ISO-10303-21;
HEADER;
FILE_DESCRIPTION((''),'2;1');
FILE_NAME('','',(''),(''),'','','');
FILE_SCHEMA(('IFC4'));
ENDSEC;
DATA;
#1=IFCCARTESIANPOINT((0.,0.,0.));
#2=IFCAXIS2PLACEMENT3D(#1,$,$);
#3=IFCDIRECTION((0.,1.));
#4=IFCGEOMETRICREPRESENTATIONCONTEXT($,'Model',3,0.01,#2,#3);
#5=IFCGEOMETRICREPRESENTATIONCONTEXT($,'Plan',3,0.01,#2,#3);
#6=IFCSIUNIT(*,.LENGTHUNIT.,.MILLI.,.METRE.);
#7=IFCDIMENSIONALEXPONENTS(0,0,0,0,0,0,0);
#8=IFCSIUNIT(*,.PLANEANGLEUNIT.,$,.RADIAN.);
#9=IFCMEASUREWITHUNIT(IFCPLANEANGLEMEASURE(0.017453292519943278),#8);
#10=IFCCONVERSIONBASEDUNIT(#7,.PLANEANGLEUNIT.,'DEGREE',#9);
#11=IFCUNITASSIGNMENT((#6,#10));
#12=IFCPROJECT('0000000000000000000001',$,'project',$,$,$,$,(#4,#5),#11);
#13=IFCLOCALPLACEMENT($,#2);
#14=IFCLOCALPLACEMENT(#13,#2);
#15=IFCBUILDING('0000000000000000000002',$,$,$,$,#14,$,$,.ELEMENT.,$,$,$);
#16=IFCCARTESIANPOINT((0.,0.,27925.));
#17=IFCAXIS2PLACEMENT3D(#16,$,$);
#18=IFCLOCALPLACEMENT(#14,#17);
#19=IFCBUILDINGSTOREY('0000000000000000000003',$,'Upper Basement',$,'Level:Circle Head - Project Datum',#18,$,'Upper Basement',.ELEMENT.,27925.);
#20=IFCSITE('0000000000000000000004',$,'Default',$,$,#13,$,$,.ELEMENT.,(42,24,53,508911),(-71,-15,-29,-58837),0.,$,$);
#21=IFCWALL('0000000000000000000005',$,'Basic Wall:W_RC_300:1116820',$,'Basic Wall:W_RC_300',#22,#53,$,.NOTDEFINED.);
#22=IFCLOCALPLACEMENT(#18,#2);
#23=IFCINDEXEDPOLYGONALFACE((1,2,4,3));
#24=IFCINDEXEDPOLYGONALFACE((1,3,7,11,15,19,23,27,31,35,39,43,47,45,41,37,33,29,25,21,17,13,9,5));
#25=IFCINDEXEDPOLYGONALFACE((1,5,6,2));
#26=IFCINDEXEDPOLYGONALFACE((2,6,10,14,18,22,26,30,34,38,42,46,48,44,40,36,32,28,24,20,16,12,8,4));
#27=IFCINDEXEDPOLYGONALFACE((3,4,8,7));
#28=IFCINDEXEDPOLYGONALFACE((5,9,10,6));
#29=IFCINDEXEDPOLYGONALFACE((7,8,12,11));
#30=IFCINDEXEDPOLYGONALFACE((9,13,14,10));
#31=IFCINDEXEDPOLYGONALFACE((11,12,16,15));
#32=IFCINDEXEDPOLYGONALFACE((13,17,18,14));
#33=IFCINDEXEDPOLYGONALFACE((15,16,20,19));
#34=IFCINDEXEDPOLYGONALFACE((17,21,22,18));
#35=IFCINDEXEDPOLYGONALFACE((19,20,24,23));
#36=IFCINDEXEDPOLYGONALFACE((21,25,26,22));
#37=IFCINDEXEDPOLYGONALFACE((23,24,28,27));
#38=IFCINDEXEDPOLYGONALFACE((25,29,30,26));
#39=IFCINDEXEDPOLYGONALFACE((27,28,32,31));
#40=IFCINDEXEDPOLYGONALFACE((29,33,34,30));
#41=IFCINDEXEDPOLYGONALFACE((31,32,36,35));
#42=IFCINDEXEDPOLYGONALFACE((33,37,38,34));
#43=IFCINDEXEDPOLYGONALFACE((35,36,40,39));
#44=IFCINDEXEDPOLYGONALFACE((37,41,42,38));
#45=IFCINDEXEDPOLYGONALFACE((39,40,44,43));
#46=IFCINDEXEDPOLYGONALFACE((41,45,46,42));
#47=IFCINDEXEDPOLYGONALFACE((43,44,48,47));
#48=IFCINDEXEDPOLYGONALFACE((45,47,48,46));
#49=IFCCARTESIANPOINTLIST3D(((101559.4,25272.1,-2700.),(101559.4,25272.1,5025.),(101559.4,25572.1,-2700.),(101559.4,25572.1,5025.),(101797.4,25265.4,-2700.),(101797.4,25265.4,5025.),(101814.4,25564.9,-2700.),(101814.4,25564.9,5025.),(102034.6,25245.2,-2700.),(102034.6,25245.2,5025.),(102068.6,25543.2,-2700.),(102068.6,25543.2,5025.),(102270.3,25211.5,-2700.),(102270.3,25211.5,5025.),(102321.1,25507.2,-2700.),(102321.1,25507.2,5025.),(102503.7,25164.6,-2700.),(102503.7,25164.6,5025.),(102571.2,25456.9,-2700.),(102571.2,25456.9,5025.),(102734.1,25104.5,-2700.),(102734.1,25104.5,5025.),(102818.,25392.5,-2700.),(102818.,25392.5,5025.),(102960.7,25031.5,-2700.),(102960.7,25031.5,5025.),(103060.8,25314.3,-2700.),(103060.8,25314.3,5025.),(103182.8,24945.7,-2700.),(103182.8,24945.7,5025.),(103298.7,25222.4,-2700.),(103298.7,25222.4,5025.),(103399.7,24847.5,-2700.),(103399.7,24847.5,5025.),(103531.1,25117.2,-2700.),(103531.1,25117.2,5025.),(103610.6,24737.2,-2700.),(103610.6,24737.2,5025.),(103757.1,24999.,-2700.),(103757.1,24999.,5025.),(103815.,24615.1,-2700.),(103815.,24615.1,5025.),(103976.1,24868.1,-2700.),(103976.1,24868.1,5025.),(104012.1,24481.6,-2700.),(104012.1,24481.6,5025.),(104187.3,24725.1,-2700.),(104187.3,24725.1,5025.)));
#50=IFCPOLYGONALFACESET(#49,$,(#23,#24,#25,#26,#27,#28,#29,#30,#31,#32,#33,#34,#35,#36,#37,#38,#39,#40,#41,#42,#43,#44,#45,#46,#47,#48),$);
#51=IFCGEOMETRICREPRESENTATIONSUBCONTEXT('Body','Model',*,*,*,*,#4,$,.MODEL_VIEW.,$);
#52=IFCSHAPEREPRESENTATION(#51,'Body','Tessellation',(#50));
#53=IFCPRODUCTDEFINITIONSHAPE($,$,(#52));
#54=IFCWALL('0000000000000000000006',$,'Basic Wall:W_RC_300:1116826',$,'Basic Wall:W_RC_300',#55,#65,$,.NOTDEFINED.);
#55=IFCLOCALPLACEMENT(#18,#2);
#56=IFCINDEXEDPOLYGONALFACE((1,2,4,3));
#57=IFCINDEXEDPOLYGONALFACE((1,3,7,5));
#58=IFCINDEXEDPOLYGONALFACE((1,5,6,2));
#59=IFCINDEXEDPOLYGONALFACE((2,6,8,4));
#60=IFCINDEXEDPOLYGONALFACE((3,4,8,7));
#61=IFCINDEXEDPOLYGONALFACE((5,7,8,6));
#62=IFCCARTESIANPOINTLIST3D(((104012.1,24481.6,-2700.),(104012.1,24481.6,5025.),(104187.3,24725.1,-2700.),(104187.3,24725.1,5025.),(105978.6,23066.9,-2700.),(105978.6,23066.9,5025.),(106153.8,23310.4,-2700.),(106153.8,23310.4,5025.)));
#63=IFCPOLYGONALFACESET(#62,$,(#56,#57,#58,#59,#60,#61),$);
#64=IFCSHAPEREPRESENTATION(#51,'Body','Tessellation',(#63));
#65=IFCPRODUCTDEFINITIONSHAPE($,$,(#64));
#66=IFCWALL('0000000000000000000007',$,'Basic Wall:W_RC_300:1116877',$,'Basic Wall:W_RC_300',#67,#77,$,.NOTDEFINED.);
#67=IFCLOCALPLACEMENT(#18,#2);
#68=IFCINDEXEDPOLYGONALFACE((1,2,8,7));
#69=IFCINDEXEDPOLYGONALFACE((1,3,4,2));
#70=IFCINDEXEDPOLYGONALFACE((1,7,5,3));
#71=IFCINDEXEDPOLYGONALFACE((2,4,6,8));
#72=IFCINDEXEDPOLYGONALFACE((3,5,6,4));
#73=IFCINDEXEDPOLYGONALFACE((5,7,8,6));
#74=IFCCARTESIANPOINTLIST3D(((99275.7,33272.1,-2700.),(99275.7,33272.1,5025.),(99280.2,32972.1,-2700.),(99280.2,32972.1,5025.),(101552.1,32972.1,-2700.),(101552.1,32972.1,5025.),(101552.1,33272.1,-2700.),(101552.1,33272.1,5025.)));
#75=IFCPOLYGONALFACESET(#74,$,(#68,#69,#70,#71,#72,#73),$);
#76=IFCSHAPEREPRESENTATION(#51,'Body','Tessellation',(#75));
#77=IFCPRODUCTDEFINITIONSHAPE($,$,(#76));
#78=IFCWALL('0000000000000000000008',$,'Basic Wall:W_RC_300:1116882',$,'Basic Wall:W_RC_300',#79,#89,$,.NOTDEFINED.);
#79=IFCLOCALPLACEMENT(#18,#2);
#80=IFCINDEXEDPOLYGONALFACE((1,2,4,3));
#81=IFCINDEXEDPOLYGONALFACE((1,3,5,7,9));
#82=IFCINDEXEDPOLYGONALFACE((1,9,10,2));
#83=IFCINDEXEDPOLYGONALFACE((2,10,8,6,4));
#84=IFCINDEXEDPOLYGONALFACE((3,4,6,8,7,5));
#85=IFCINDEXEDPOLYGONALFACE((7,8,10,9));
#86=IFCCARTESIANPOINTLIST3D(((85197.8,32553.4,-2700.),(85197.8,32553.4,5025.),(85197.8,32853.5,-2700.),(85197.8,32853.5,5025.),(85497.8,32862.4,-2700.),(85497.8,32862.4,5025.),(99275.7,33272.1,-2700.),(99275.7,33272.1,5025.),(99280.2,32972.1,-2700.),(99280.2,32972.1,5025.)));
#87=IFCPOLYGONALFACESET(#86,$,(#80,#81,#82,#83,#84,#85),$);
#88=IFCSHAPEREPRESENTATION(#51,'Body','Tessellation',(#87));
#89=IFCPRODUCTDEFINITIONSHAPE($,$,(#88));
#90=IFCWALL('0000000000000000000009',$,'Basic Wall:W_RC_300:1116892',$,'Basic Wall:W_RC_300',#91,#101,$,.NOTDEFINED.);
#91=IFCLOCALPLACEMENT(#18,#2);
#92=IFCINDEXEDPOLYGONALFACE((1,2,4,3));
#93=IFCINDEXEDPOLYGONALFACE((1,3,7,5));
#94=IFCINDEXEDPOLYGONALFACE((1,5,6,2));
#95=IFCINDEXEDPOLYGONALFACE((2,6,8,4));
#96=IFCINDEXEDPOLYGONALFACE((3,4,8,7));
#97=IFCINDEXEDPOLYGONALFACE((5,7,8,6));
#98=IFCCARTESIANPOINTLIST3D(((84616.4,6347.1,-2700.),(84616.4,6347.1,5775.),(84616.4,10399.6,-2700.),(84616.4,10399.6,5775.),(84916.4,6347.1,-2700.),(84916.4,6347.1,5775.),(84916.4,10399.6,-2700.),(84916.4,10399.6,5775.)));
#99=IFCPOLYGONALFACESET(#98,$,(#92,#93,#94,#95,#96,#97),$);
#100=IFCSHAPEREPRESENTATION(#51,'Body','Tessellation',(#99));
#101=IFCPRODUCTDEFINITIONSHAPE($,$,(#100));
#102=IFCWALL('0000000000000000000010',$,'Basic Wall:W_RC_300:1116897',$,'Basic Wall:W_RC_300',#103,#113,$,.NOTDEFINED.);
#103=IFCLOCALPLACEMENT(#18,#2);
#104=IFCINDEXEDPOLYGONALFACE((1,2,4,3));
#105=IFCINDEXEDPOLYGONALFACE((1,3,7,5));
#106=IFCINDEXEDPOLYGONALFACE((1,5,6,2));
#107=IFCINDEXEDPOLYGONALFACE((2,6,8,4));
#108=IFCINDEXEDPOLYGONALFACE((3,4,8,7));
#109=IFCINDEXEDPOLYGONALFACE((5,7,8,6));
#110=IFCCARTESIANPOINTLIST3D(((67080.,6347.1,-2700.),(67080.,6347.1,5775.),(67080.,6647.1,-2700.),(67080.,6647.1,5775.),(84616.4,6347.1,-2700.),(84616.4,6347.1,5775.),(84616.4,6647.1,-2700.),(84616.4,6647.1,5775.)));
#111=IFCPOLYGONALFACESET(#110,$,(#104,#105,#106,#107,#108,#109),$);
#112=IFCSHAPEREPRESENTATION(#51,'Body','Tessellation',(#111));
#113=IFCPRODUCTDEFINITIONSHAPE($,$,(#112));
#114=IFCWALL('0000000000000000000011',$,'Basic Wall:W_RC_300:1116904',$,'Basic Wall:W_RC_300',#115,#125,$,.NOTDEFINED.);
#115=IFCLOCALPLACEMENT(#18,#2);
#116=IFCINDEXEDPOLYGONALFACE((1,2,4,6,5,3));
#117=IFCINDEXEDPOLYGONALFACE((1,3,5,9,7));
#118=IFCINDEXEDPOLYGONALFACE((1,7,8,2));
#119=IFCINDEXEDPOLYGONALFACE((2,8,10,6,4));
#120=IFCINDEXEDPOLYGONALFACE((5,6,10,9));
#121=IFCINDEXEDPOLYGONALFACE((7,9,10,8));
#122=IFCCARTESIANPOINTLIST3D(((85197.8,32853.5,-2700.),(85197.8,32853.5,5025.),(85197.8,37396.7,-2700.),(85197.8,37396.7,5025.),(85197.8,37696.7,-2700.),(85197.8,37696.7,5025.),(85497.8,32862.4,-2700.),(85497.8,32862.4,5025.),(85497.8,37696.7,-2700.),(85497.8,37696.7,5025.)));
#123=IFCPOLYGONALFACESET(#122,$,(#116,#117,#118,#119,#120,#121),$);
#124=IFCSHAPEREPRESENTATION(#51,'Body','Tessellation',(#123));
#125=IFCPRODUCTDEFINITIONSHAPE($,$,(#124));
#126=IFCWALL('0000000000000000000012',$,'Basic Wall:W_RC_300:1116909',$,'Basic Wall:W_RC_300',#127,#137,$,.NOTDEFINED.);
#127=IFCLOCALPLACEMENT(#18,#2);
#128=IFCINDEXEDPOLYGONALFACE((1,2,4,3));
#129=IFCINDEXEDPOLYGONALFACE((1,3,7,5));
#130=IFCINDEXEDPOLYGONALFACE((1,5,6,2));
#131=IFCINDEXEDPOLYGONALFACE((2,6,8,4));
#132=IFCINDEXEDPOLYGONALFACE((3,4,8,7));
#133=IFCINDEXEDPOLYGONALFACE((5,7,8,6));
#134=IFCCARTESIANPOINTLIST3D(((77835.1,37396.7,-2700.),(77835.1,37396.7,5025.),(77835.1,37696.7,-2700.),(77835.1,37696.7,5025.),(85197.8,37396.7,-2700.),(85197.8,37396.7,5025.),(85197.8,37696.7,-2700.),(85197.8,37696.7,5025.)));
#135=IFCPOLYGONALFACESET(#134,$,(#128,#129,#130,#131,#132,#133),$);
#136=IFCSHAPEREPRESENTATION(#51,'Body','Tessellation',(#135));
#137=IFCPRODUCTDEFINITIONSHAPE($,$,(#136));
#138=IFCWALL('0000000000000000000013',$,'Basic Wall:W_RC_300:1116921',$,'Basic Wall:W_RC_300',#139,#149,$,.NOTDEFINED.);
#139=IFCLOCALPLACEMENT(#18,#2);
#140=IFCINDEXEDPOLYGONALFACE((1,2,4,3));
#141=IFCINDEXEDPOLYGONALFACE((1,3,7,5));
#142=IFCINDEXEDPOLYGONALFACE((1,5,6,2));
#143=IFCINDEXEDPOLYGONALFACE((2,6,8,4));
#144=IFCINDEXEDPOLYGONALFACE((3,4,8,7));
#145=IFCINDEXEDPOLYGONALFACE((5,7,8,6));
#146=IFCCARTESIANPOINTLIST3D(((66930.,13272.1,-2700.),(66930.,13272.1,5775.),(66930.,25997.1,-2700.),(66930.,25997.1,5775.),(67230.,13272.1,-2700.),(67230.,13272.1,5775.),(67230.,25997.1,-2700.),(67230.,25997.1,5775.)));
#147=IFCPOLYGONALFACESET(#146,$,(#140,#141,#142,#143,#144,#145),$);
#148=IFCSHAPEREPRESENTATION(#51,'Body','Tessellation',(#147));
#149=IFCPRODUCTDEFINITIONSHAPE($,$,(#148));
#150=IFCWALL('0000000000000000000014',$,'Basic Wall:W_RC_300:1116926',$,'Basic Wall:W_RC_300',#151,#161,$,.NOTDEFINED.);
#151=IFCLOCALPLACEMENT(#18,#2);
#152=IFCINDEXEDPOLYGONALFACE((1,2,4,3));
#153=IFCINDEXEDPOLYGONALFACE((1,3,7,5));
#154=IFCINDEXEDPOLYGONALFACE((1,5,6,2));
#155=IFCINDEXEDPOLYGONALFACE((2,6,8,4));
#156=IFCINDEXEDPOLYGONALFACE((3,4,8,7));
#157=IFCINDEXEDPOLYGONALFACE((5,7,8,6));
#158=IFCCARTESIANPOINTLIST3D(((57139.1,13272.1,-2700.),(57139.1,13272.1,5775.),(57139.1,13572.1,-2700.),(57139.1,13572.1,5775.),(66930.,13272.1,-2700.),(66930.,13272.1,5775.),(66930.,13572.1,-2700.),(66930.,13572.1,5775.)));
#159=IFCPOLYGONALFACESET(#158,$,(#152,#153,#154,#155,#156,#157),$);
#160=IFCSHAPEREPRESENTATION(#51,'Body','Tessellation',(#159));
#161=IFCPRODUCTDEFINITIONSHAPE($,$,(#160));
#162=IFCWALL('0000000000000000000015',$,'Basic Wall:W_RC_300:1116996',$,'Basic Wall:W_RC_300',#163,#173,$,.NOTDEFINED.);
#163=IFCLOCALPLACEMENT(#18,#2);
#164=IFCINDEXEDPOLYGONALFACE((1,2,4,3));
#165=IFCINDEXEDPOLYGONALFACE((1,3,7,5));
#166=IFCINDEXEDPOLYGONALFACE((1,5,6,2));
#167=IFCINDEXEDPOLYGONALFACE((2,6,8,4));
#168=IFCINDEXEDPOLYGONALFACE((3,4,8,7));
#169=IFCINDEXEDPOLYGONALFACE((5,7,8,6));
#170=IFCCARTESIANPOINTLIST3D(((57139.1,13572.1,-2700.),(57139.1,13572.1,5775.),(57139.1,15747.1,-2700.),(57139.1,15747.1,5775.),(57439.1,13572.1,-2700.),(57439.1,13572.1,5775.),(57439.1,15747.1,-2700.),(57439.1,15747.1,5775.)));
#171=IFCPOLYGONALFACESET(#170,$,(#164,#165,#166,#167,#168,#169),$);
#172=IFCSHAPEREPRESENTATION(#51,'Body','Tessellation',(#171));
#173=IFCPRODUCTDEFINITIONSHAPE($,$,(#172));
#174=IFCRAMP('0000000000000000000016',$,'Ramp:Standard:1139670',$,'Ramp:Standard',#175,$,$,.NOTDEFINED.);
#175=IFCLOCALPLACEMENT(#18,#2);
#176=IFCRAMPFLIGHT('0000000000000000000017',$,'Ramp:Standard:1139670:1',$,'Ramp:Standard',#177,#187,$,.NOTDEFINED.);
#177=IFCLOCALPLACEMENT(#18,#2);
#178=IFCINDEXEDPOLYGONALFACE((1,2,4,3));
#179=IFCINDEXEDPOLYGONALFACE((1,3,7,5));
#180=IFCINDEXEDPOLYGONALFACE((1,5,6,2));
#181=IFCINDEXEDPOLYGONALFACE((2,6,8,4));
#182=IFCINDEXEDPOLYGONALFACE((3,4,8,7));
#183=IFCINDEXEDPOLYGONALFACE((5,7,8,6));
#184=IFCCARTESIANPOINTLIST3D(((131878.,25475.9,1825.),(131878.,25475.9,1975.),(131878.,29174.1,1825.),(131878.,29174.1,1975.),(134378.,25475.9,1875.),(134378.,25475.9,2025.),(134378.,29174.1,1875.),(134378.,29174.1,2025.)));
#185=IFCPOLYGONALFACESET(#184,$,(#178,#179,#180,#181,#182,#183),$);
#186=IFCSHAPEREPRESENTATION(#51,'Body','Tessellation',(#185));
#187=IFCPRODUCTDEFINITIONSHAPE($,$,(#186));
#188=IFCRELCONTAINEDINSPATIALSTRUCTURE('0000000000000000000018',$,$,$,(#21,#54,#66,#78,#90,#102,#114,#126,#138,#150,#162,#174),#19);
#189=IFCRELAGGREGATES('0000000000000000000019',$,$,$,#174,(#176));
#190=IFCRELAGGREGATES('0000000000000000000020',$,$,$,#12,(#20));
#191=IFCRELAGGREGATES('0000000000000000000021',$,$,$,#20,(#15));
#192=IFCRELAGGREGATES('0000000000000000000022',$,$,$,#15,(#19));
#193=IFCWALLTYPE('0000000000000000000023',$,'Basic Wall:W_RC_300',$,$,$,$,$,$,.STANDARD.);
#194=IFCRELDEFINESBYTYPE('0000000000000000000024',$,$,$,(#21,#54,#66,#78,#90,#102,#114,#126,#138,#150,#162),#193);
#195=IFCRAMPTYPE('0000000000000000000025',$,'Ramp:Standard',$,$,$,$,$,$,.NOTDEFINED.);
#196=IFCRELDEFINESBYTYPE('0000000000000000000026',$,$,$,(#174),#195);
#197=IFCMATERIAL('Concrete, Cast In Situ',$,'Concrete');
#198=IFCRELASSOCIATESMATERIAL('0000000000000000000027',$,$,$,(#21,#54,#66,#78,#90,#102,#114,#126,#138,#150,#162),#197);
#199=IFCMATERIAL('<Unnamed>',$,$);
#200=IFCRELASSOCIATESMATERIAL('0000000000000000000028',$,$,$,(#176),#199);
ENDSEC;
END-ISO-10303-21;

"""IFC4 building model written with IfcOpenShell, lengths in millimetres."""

from ifc_helpers import new_model, entity, si_unit, converted_unit, direction, frame, origin, place, context, subcontext, project, spatial, line, arc, indexed_curve, outline, extrude, material, type_object, element, aggregate, save


model = new_model("IFC4")

# Units and contexts
model_context = context("Model", 3, precision=0.01, world=origin(), true_north=direction((0.0, 1.0)))
plan_context = context("Plan", 3, precision=0.01, world=origin(), true_north=direction((0.0, 1.0)))
body_context = subcontext(model_context, "Body", "Model", "MODEL_VIEW")
ifc_project = project(units=[si_unit("LENGTHUNIT", "METRE", prefix="MILLI"), converted_unit("PLANEANGLEUNIT", "DEGREE", entity("IfcPlaneAngleMeasure", 0.017453292519943278), si_unit("PLANEANGLEUNIT", "RADIAN"), dimensions=[0, 0, 0, 0, 0, 0, 0])], contexts=[model_context, plan_context])

# Site, building, storey
site_placement = place(None, origin())
site = spatial("IfcSite", under=ifc_project, at=site_placement, Name="Default", CompositionType="ELEMENT", RefLatitude=(42, 24, 53, 508911), RefLongitude=(-71, -15, -29, -58837), RefElevation=0.0)
building_placement = place(site_placement, origin())
building = spatial("IfcBuilding", under=site, at=building_placement, CompositionType="ELEMENT")
storey_placement = place(building_placement, frame((0.0, 0.0, 27925.0)))
storey = spatial("IfcBuildingStorey", under=building, at=storey_placement, Name="Upper Basement", ObjectType="Level:Circle Head - Project Datum", LongName="Upper Basement", CompositionType="ELEMENT", Elevation=27925.0)

# Walls
ifc_material_1 = material(Name="Concrete, Cast In Situ", Category="Concrete")
wall_type = type_object("IfcWallType", Name="Basic Wall:W_RC_300", PredefinedType="STANDARD")
wall_1_placement = place(storey_placement, frame((101559.4, 25422.1, -2700.0)))
element("IfcWall", 1, at=wall_1_placement, inside=storey, type_object=wall_type, material=ifc_material_1, Name="Basic Wall:W_RC_300:1116820", ObjectType="Basic Wall:W_RC_300", PredefinedType="NOTDEFINED", context=body_context, shape_type="SweptSolid", body=[
    extrude(outline(indexed_curve([(2627.9, -697.0), (1380.5, -67.0), (0.0, 150.0), (0.0, -150.0), (1288.5, -352.5), (2452.7, -940.6)], segments=[arc(1, 2, 3), line(3, 4), arc(4, 5, 6), line(6, 1)], self_intersect=False)), origin(), (0.0, 0.0, 1.0), 7725.0),
])
wall_2_placement = place(storey_placement, frame((104099.7, 24603.3, -2700.0), z_axis=(0.0, 0.0, 1.0), x_axis=(0.811769, -0.583979, 0.0)))
element("IfcWall", 2, at=wall_2_placement, inside=storey, type_object=wall_type, material=ifc_material_1, Name="Basic Wall:W_RC_300:1116826", ObjectType="Basic Wall:W_RC_300", PredefinedType="NOTDEFINED", context=body_context, shape_type="SweptSolid", body=[
    extrude(outline(indexed_curve([(2422.5, 150.0), (0.0, 150.0), (0.0, -150.0), (2422.5, -150.0), (2422.5, 150.0)], self_intersect=False)), origin(), (0.0, 0.0, 1.0), 7725.0),
])
wall_3_placement = place(storey_placement, frame((101552.1, 33122.1, -2700.0), z_axis=(0.0, 0.0, 1.0), x_axis=(-1.0, 0.0, 0.0)))
element("IfcWall", 3, at=wall_3_placement, inside=storey, type_object=wall_type, material=ifc_material_1, Name="Basic Wall:W_RC_300:1116877", ObjectType="Basic Wall:W_RC_300", PredefinedType="NOTDEFINED", context=body_context, shape_type="SweptSolid", body=[
    extrude(outline(indexed_curve([(2276.4, -150.0), (2271.9, 150.0), (0.0, 150.0), (0.0, -150.0), (2276.4, -150.0)], self_intersect=False)), origin(), (0.0, 0.0, 1.0), 7725.0),
])
wall_4_placement = place(storey_placement, frame((99280.2, 33122.2, -2700.0), z_axis=(0.0, 0.0, 1.0), x_axis=(-0.999558, -0.029722, 0.0)))
element("IfcWall", 4, at=wall_4_placement, inside=storey, type_object=wall_type, material=ifc_material_1, Name="Basic Wall:W_RC_300:1116882", ObjectType="Basic Wall:W_RC_300", PredefinedType="NOTDEFINED", context=body_context, shape_type="SweptSolid", body=[
    extrude(outline(indexed_curve([(14084.1, -150.0), (14093.0, 150.0), (4.5, 150.0), (0.0, -150.0), (13784.0, -150.0), (14084.1, -150.0)], self_intersect=False)), origin(), (0.0, 0.0, 1.0), 7725.0),
])
wall_5_placement = place(storey_placement, frame((84766.4, 6347.1, -2700.0), z_axis=(0.0, 0.0, 1.0), x_axis=(0.0, 1.0, 0.0)))
element("IfcWall", 5, at=wall_5_placement, inside=storey, type_object=wall_type, material=ifc_material_1, Name="Basic Wall:W_RC_300:1116892", ObjectType="Basic Wall:W_RC_300", PredefinedType="NOTDEFINED", context=body_context, shape_type="SweptSolid", body=[
    extrude(outline(indexed_curve([(4052.5, 150.0), (0.0, 150.0), (0.0, -150.0), (4052.5, -150.0), (4052.5, 150.0)], self_intersect=False)), origin(), (0.0, 0.0, 1.0), 8475.0),
])
wall_6_placement = place(storey_placement, frame((67080.0, 6497.1, -2700.0)))
element("IfcWall", 6, at=wall_6_placement, inside=storey, type_object=wall_type, material=ifc_material_1, Name="Basic Wall:W_RC_300:1116897", ObjectType="Basic Wall:W_RC_300", PredefinedType="NOTDEFINED", context=body_context, shape_type="SweptSolid", body=[
    extrude(outline(indexed_curve([(17536.3, 150.0), (0.0, 150.0), (0.0, -150.0), (17536.3, -150.0), (17536.3, 150.0)], self_intersect=False)), origin(), (0.0, 0.0, 1.0), 8475.0),
])
wall_7_placement = place(storey_placement, frame((85347.8, 32853.5, -2700.0), z_axis=(0.0, 0.0, 1.0), x_axis=(0.0, 1.0, 0.0)))
element("IfcWall", 7, at=wall_7_placement, inside=storey, type_object=wall_type, material=ifc_material_1, Name="Basic Wall:W_RC_300:1116904", ObjectType="Basic Wall:W_RC_300", PredefinedType="NOTDEFINED", context=body_context, shape_type="SweptSolid", body=[
    extrude(outline(indexed_curve([(4843.1, -150.0), (4843.1, 150.0), (4543.1, 150.0), (0.0, 150.0), (8.9, -150.0), (4843.1, -150.0)], self_intersect=False)), origin(), (0.0, 0.0, 1.0), 7725.0),
])
wall_8_placement = place(storey_placement, frame((85197.8, 37546.7, -2700.0), z_axis=(0.0, 0.0, 1.0), x_axis=(-1.0, 0.0, 0.0)))
element("IfcWall", 8, at=wall_8_placement, inside=storey, type_object=wall_type, material=ifc_material_1, Name="Basic Wall:W_RC_300:1116909", ObjectType="Basic Wall:W_RC_300", PredefinedType="NOTDEFINED", context=body_context, shape_type="SweptSolid", body=[
    extrude(outline(indexed_curve([(7362.7, 150.0), (0.0, 150.0), (0.0, -150.0), (7362.7, -150.0), (7362.7, 150.0)], self_intersect=False)), origin(), (0.0, 0.0, 1.0), 7725.0),
])
wall_9_placement = place(storey_placement, frame((67080.0, 25997.1, -2700.0), z_axis=(0.0, 0.0, 1.0), x_axis=(0.0, -1.0, 0.0)))
element("IfcWall", 9, at=wall_9_placement, inside=storey, type_object=wall_type, material=ifc_material_1, Name="Basic Wall:W_RC_300:1116921", ObjectType="Basic Wall:W_RC_300", PredefinedType="NOTDEFINED", context=body_context, shape_type="SweptSolid", body=[
    extrude(outline(indexed_curve([(12725.0, 150.0), (0.0, 150.0), (0.0, -150.0), (12725.0, -150.0), (12725.0, 150.0)], self_intersect=False)), origin(), (0.0, 0.0, 1.0), 8475.0),
])
wall_10_placement = place(storey_placement, frame((66930.0, 13422.1, -2700.0), z_axis=(0.0, 0.0, 1.0), x_axis=(-1.0, 0.0, 0.0)))
element("IfcWall", 10, at=wall_10_placement, inside=storey, type_object=wall_type, material=ifc_material_1, Name="Basic Wall:W_RC_300:1116926", ObjectType="Basic Wall:W_RC_300", PredefinedType="NOTDEFINED", context=body_context, shape_type="SweptSolid", body=[
    extrude(outline(indexed_curve([(9791.0, 150.0), (0.0, 150.0), (0.0, -150.0), (9791.0, -150.0), (9791.0, 150.0)], self_intersect=False)), origin(), (0.0, 0.0, 1.0), 8475.0),
])
wall_11_placement = place(storey_placement, frame((57289.1, 13572.1, -2700.0), z_axis=(0.0, 0.0, 1.0), x_axis=(0.0, 1.0, 0.0)))
element("IfcWall", 11, at=wall_11_placement, inside=storey, type_object=wall_type, material=ifc_material_1, Name="Basic Wall:W_RC_300:1116996", ObjectType="Basic Wall:W_RC_300", PredefinedType="NOTDEFINED", context=body_context, shape_type="SweptSolid", body=[
    extrude(outline(indexed_curve([(2175.0, 150.0), (0.0, 150.0), (0.0, -150.0), (2175.0, -150.0), (2175.0, 150.0)], self_intersect=False)), origin(), (0.0, 0.0, 1.0), 8475.0),
])

# Ramp, ramp flight
ramp_type = type_object("IfcRampType", Name="Ramp:Standard", PredefinedType="NOTDEFINED")
ramp_1_placement = place(storey_placement, origin())
ramp_1 = element("IfcRamp", 12, at=ramp_1_placement, inside=storey, type_object=ramp_type, Name="Ramp:Standard:1139670", ObjectType="Ramp:Standard", PredefinedType="NOTDEFINED")
ifc_material_2 = material(Name="<Unnamed>")
ramp_flight_1_placement = place(ramp_1_placement, origin())
ramp_flight_1 = element("IfcRampFlight", 13, at=ramp_flight_1_placement, material=ifc_material_2, Name="Ramp:Standard:1139670:1", ObjectType="Ramp:Standard", PredefinedType="NOTDEFINED", context=body_context, shape_type="SweptSolid", body=[
    extrude(outline(indexed_curve([(-100.0, -1250.0), (50.0, -1250.0), (100.0, 1250.0), (-50.0, 1250.0), (-100.0, -1250.0)], self_intersect=False)), frame((133128.0, 25475.9, 1925.0), z_axis=(0.0, 1.0, 0.0), x_axis=(0.0, 0.0, -1.0)), (0.0, 0.0, 1.0), 3698.2),
])
aggregate(ramp_1, [ramp_flight_1])

save(model, "model.ifc")
